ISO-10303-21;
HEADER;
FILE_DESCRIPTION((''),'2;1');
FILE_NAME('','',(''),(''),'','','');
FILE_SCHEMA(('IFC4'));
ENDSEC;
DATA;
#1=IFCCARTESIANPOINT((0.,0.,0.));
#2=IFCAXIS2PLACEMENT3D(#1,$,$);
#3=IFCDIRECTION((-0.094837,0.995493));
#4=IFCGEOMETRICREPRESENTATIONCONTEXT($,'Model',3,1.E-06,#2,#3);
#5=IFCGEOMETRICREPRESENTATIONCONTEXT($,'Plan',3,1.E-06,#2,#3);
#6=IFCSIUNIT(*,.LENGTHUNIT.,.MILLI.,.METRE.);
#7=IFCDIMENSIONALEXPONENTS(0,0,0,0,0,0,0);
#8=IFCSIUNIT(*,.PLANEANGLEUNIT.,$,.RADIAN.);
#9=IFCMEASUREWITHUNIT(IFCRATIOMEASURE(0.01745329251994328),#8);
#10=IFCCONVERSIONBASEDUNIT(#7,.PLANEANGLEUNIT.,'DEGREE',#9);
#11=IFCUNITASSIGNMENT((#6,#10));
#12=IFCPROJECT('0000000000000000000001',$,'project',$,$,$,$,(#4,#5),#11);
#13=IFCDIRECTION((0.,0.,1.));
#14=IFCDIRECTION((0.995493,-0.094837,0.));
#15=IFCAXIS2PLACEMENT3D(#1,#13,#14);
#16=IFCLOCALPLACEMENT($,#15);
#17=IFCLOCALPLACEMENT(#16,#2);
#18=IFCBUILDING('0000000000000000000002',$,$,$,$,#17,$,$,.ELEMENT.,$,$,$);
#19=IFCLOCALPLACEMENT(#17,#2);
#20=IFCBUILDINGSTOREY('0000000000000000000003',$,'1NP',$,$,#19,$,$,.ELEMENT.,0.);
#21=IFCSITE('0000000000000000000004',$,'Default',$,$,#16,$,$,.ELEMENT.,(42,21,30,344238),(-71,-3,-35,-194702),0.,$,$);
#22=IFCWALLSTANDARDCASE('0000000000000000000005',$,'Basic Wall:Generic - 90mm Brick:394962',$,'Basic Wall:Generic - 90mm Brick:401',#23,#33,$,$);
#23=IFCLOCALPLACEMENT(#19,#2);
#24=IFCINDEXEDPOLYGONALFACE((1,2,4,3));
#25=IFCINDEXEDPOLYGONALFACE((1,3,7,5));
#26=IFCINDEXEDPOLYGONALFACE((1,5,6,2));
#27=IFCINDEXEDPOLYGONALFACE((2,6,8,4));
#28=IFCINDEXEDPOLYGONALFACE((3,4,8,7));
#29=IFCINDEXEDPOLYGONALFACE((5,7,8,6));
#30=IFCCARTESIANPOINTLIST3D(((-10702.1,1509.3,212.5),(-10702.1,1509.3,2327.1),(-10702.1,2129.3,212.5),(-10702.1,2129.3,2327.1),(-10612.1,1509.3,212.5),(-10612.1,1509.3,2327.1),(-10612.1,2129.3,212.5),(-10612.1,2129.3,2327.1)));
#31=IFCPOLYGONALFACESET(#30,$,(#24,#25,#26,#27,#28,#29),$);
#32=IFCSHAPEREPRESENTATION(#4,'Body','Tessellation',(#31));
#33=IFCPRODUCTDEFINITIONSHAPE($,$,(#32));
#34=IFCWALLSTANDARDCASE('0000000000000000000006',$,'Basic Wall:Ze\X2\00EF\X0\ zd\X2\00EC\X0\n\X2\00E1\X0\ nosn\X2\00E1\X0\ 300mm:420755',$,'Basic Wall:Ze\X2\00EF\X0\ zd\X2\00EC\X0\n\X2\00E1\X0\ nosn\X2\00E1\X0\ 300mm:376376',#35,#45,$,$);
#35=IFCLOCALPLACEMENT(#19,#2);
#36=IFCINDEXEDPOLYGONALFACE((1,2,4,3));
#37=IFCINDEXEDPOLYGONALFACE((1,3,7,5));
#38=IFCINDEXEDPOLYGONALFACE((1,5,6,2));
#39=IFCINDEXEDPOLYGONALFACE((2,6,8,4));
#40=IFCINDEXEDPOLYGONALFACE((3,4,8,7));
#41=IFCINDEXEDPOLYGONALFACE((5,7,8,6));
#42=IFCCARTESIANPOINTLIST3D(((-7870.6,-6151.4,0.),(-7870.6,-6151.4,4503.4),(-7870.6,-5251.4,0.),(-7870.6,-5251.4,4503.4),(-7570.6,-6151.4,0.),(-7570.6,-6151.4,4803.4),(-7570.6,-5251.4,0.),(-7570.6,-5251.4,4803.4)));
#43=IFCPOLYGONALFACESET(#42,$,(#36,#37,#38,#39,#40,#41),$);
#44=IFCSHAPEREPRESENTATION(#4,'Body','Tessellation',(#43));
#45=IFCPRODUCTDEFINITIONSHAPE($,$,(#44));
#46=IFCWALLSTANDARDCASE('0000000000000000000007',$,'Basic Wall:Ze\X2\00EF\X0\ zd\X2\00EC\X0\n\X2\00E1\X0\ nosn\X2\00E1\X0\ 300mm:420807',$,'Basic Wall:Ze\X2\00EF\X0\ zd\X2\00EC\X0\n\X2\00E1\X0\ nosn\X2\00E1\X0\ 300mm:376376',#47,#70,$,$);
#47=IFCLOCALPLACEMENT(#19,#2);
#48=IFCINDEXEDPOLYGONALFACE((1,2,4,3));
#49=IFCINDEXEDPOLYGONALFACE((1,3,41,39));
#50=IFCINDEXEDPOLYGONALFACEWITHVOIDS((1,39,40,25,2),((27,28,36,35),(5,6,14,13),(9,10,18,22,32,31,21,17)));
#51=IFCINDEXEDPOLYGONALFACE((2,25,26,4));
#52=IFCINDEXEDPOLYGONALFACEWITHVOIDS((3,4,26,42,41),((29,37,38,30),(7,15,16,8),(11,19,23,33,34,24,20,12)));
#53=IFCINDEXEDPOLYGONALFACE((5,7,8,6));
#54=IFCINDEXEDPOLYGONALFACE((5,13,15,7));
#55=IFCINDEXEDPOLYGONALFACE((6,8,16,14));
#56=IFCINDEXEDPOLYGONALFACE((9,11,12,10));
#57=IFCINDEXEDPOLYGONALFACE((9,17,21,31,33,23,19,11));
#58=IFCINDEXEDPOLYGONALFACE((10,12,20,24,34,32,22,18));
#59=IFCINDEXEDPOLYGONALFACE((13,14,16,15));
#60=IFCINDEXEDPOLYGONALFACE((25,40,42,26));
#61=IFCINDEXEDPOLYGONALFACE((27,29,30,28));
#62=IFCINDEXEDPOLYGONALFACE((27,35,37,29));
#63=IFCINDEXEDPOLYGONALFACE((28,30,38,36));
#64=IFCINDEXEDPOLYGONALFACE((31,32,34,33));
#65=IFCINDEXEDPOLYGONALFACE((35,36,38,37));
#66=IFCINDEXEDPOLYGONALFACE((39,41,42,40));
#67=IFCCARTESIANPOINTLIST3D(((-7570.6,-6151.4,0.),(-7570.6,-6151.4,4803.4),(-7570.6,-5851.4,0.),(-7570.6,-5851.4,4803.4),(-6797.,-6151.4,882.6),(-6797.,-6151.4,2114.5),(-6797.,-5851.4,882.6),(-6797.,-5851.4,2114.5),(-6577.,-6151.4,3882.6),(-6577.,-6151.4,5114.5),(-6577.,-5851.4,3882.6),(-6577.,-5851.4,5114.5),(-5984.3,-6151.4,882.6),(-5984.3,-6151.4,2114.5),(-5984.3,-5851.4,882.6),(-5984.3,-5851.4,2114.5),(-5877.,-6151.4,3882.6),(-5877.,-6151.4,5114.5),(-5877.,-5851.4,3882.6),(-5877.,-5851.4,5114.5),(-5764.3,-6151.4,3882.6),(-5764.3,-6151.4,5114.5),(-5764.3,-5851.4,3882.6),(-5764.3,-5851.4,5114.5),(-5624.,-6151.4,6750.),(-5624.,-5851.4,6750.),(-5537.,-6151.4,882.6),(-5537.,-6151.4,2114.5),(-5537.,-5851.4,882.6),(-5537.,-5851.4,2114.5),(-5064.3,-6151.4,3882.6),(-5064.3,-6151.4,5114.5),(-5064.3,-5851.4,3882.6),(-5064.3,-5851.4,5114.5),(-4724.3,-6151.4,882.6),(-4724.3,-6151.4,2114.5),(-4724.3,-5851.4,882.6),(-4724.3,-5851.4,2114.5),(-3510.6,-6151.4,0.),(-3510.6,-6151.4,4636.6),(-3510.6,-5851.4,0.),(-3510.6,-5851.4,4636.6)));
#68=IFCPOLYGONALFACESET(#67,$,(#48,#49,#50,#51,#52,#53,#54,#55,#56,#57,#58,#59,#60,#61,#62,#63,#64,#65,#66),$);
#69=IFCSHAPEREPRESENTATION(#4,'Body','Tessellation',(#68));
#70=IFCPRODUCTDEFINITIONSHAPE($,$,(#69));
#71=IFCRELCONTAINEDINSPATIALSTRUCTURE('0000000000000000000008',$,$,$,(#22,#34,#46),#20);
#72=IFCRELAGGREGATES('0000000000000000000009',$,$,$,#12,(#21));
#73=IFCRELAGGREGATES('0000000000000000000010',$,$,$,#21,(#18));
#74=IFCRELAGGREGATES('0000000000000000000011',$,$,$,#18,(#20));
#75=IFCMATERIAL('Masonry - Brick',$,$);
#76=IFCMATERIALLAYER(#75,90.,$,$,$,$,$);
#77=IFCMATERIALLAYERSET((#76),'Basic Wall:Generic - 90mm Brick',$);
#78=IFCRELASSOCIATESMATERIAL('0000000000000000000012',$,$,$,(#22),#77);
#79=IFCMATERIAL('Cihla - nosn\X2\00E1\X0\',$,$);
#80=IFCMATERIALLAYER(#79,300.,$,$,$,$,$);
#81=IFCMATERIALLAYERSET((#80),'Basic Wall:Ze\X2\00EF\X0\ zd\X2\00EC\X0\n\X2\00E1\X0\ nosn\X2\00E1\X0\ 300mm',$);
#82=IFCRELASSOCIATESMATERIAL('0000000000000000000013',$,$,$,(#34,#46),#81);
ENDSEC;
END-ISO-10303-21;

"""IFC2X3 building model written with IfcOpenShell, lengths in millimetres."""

from ifc_helpers import new_model, entity, si_unit, converted_unit, direction, frame, frame_2d, origin, place, context, project, spatial, polyline, rectangle, extrude, clip, bounded_halfspace, material, layer, layer_set, layer_usage, element, save


model = new_model("IFC2X3")

# Units and contexts
model_context = context("Model", 3, precision=1e-06, world=origin(), true_north=direction((-0.094837, 0.995493)))
plan_context = context("Plan", 3, precision=1e-06, world=origin(), true_north=direction((-0.094837, 0.995493)))
ifc_project = project(units=[si_unit("LENGTHUNIT", "METRE", prefix="MILLI"), converted_unit("PLANEANGLEUNIT", "DEGREE", entity("IfcRatioMeasure", 0.01745329251994328), si_unit("PLANEANGLEUNIT", "RADIAN"), dimensions=[0, 0, 0, 0, 0, 0, 0])], contexts=[model_context, plan_context])

# Site, building, storey
site_placement = place(None, frame((0.0, 0.0, 0.0), z_axis=(0.0, 0.0, 1.0), x_axis=(0.995493, -0.094837, 0.0)))
site = spatial("IfcSite", under=ifc_project, at=site_placement, Name="Default", CompositionType="ELEMENT", RefLatitude=(42, 21, 30, 344238), RefLongitude=(-71, -3, -35, -194702), RefElevation=0.0)
building_placement = place(site_placement, origin())
building = spatial("IfcBuilding", under=site, at=building_placement, CompositionType="ELEMENT")
storey_placement = place(building_placement, origin())
storey = spatial("IfcBuildingStorey", under=building, at=storey_placement, Name="1NP", CompositionType="ELEMENT", Elevation=0.0)

# Shared definitions
ifc_material_1 = material(Name="Cihla - nosná")
ifc_layer_1 = layer(ifc_material_1, 300.0)
ifc_layer_set_1 = layer_set([ifc_layer_1], Name="Basic Wall:Zeï zdìná nosná 300mm")

# Walls
ifc_material_2 = material(Name="Masonry - Brick")
ifc_layer_2 = layer(ifc_material_2, 90.0)
ifc_layer_set_2 = layer_set([ifc_layer_2], Name="Basic Wall:Generic - 90mm Brick")
ifc_layer_usage_1 = layer_usage(ifc_layer_set_2, "AXIS2", "NEGATIVE", 45.0)
wall_1_placement = place(storey_placement, frame((-10657.1, 1509.3, 212.5), z_axis=(0.0, 0.0, 1.0), x_axis=(0.0, 1.0, 0.0)))
element("IfcWallStandardCase", 1, at=wall_1_placement, inside=storey, material=ifc_layer_usage_1, Name="Basic Wall:Generic - 90mm Brick:394962", ObjectType="Basic Wall:Generic - 90mm Brick:401", context=model_context, shape_type="SweptSolid", body=[
    extrude(rectangle(XDim=620.0, YDim=90.0, at=frame_2d((310.0, 0.0), x_axis=(-1.0, 0.0))), origin(), (0.0, 0.0, 1.0), 2114.6),
])
ifc_layer_usage_2 = layer_usage(ifc_layer_set_1, "AXIS2", "POSITIVE", -150.0)
wall_2_placement = place(storey_placement, frame((-7720.6, -5251.4, 0.0), z_axis=(0.0, 0.0, 1.0), x_axis=(0.0, -1.0, 0.0)))
element("IfcWallStandardCase", 2, at=wall_2_placement, inside=storey, material=ifc_layer_usage_2, Name="Basic Wall:Zeï zdìná nosná 300mm:420755", ObjectType="Basic Wall:Zeï zdìná nosná 300mm:376376", context=model_context, shape_type="Clipping", body=[
    clip(extrude(rectangle(XDim=900.0, YDim=300.0, at=frame_2d((450.0, 0.0), x_axis=(-1.0, 0.0))), origin(), (0.0, 0.0, 1.0), 4803.4), bounded_halfspace(frame((0.0, -150.0, 4503.4), z_axis=(0.0, -0.707107, 0.707107), x_axis=(1.0, 0.0, 0.0)), False, frame((0.0, -150.0, 4503.4)), polyline([(0.0, 0.0), (900.0, 0.0), (900.0, 300.0), (600.0, 300.0), (0.0, 300.0), (0.0, 0.0)]))),
])

# Wall, openings
ifc_layer_usage_3 = layer_usage(ifc_layer_set_1, "AXIS2", "POSITIVE", -150.0)
wall_3_placement = place(storey_placement, frame((-7570.6, -6001.4, 0.0)))
wall_3 = element("IfcWallStandardCase", 3, at=wall_3_placement, inside=storey, material=ifc_layer_usage_3, Name="Basic Wall:Zeï zdìná nosná 300mm:420807", ObjectType="Basic Wall:Zeï zdìná nosná 300mm:376376", context=model_context, shape_type="Clipping", body=[
    clip(clip(extrude(rectangle(XDim=4060.0, YDim=300.0, at=frame_2d((2030.0, 0.0), x_axis=(-1.0, 0.0))), origin(), (0.0, 0.0, 1.0), 6750.0), bounded_halfspace(frame((4060.0, -150.0, 4636.6), z_axis=(0.707107, 0.0, 0.707107), x_axis=(0.0, 1.0, 0.0)), False, frame((4060.0, -150.0, 4636.6)), polyline([(0.0, 0.0), (0.0, 300.0), (-300.0, 300.0), (-2113.4, 300.0), (-2113.4, 0.0), (0.0, 0.0)]))), bounded_halfspace(frame((0.0, 150.0, 4803.4), z_axis=(-0.707107, 0.0, 0.707107), x_axis=(0.0, -1.0, 0.0)), False, frame((0.0, 150.0, 4803.4)), polyline([(0.0, 0.0), (0.0, -300.0), (1946.6, -300.0), (1946.6, 0.0), (0.0, 0.0)]))),
])
opening_1_placement = place(wall_3_placement, frame((1806.4, 150.0, 3882.6)))
element("IfcOpeningElement", 4, at=opening_1_placement, cuts=wall_3, ObjectType="Opening", context=model_context, shape_type="SweptSolid", body=[
    extrude(rectangle(XDim=1231.9, YDim=812.7, at=frame_2d((615.9, 406.4), x_axis=(-1.0, 0.0))), frame((0.0, 0.0, 0.0), z_axis=(0.0, -1.0, 0.0), x_axis=(0.0, 0.0, 1.0)), (0.0, 0.0, 1.0), 300.0),
])
opening_2_placement = place(wall_3_placement, frame((2506.4, 150.0, 3882.6)))
element("IfcOpeningElement", 5, at=opening_2_placement, cuts=wall_3, ObjectType="Opening", context=model_context, shape_type="SweptSolid", body=[
    extrude(rectangle(XDim=1231.9, YDim=812.7, at=frame_2d((615.9, 406.4), x_axis=(-1.0, 0.0))), frame((0.0, 0.0, 0.0), z_axis=(0.0, -1.0, 0.0), x_axis=(0.0, 0.0, 1.0)), (0.0, 0.0, 1.0), 300.0),
])
opening_3_placement = place(wall_3_placement, frame((2846.3, 150.0, 882.6)))
element("IfcOpeningElement", 6, at=opening_3_placement, cuts=wall_3, ObjectType="Opening", context=model_context, shape_type="SweptSolid", body=[
    extrude(rectangle(XDim=1231.9, YDim=812.7, at=frame_2d((615.9, 406.4), x_axis=(-1.0, 0.0))), frame((0.0, 0.0, 0.0), z_axis=(0.0, -1.0, 0.0), x_axis=(0.0, 0.0, 1.0)), (0.0, 0.0, 1.0), 300.0),
])
opening_4_placement = place(wall_3_placement, frame((1586.4, 150.0, 882.6)))
element("IfcOpeningElement", 7, at=opening_4_placement, cuts=wall_3, ObjectType="Opening", context=model_context, shape_type="SweptSolid", body=[
    extrude(rectangle(XDim=1231.9, YDim=812.7, at=frame_2d((615.9, 406.4), x_axis=(-1.0, 0.0))), frame((0.0, 0.0, 0.0), z_axis=(0.0, -1.0, 0.0), x_axis=(0.0, 0.0, 1.0)), (0.0, 0.0, 1.0), 300.0),
])

save(model, "model.ifc")
